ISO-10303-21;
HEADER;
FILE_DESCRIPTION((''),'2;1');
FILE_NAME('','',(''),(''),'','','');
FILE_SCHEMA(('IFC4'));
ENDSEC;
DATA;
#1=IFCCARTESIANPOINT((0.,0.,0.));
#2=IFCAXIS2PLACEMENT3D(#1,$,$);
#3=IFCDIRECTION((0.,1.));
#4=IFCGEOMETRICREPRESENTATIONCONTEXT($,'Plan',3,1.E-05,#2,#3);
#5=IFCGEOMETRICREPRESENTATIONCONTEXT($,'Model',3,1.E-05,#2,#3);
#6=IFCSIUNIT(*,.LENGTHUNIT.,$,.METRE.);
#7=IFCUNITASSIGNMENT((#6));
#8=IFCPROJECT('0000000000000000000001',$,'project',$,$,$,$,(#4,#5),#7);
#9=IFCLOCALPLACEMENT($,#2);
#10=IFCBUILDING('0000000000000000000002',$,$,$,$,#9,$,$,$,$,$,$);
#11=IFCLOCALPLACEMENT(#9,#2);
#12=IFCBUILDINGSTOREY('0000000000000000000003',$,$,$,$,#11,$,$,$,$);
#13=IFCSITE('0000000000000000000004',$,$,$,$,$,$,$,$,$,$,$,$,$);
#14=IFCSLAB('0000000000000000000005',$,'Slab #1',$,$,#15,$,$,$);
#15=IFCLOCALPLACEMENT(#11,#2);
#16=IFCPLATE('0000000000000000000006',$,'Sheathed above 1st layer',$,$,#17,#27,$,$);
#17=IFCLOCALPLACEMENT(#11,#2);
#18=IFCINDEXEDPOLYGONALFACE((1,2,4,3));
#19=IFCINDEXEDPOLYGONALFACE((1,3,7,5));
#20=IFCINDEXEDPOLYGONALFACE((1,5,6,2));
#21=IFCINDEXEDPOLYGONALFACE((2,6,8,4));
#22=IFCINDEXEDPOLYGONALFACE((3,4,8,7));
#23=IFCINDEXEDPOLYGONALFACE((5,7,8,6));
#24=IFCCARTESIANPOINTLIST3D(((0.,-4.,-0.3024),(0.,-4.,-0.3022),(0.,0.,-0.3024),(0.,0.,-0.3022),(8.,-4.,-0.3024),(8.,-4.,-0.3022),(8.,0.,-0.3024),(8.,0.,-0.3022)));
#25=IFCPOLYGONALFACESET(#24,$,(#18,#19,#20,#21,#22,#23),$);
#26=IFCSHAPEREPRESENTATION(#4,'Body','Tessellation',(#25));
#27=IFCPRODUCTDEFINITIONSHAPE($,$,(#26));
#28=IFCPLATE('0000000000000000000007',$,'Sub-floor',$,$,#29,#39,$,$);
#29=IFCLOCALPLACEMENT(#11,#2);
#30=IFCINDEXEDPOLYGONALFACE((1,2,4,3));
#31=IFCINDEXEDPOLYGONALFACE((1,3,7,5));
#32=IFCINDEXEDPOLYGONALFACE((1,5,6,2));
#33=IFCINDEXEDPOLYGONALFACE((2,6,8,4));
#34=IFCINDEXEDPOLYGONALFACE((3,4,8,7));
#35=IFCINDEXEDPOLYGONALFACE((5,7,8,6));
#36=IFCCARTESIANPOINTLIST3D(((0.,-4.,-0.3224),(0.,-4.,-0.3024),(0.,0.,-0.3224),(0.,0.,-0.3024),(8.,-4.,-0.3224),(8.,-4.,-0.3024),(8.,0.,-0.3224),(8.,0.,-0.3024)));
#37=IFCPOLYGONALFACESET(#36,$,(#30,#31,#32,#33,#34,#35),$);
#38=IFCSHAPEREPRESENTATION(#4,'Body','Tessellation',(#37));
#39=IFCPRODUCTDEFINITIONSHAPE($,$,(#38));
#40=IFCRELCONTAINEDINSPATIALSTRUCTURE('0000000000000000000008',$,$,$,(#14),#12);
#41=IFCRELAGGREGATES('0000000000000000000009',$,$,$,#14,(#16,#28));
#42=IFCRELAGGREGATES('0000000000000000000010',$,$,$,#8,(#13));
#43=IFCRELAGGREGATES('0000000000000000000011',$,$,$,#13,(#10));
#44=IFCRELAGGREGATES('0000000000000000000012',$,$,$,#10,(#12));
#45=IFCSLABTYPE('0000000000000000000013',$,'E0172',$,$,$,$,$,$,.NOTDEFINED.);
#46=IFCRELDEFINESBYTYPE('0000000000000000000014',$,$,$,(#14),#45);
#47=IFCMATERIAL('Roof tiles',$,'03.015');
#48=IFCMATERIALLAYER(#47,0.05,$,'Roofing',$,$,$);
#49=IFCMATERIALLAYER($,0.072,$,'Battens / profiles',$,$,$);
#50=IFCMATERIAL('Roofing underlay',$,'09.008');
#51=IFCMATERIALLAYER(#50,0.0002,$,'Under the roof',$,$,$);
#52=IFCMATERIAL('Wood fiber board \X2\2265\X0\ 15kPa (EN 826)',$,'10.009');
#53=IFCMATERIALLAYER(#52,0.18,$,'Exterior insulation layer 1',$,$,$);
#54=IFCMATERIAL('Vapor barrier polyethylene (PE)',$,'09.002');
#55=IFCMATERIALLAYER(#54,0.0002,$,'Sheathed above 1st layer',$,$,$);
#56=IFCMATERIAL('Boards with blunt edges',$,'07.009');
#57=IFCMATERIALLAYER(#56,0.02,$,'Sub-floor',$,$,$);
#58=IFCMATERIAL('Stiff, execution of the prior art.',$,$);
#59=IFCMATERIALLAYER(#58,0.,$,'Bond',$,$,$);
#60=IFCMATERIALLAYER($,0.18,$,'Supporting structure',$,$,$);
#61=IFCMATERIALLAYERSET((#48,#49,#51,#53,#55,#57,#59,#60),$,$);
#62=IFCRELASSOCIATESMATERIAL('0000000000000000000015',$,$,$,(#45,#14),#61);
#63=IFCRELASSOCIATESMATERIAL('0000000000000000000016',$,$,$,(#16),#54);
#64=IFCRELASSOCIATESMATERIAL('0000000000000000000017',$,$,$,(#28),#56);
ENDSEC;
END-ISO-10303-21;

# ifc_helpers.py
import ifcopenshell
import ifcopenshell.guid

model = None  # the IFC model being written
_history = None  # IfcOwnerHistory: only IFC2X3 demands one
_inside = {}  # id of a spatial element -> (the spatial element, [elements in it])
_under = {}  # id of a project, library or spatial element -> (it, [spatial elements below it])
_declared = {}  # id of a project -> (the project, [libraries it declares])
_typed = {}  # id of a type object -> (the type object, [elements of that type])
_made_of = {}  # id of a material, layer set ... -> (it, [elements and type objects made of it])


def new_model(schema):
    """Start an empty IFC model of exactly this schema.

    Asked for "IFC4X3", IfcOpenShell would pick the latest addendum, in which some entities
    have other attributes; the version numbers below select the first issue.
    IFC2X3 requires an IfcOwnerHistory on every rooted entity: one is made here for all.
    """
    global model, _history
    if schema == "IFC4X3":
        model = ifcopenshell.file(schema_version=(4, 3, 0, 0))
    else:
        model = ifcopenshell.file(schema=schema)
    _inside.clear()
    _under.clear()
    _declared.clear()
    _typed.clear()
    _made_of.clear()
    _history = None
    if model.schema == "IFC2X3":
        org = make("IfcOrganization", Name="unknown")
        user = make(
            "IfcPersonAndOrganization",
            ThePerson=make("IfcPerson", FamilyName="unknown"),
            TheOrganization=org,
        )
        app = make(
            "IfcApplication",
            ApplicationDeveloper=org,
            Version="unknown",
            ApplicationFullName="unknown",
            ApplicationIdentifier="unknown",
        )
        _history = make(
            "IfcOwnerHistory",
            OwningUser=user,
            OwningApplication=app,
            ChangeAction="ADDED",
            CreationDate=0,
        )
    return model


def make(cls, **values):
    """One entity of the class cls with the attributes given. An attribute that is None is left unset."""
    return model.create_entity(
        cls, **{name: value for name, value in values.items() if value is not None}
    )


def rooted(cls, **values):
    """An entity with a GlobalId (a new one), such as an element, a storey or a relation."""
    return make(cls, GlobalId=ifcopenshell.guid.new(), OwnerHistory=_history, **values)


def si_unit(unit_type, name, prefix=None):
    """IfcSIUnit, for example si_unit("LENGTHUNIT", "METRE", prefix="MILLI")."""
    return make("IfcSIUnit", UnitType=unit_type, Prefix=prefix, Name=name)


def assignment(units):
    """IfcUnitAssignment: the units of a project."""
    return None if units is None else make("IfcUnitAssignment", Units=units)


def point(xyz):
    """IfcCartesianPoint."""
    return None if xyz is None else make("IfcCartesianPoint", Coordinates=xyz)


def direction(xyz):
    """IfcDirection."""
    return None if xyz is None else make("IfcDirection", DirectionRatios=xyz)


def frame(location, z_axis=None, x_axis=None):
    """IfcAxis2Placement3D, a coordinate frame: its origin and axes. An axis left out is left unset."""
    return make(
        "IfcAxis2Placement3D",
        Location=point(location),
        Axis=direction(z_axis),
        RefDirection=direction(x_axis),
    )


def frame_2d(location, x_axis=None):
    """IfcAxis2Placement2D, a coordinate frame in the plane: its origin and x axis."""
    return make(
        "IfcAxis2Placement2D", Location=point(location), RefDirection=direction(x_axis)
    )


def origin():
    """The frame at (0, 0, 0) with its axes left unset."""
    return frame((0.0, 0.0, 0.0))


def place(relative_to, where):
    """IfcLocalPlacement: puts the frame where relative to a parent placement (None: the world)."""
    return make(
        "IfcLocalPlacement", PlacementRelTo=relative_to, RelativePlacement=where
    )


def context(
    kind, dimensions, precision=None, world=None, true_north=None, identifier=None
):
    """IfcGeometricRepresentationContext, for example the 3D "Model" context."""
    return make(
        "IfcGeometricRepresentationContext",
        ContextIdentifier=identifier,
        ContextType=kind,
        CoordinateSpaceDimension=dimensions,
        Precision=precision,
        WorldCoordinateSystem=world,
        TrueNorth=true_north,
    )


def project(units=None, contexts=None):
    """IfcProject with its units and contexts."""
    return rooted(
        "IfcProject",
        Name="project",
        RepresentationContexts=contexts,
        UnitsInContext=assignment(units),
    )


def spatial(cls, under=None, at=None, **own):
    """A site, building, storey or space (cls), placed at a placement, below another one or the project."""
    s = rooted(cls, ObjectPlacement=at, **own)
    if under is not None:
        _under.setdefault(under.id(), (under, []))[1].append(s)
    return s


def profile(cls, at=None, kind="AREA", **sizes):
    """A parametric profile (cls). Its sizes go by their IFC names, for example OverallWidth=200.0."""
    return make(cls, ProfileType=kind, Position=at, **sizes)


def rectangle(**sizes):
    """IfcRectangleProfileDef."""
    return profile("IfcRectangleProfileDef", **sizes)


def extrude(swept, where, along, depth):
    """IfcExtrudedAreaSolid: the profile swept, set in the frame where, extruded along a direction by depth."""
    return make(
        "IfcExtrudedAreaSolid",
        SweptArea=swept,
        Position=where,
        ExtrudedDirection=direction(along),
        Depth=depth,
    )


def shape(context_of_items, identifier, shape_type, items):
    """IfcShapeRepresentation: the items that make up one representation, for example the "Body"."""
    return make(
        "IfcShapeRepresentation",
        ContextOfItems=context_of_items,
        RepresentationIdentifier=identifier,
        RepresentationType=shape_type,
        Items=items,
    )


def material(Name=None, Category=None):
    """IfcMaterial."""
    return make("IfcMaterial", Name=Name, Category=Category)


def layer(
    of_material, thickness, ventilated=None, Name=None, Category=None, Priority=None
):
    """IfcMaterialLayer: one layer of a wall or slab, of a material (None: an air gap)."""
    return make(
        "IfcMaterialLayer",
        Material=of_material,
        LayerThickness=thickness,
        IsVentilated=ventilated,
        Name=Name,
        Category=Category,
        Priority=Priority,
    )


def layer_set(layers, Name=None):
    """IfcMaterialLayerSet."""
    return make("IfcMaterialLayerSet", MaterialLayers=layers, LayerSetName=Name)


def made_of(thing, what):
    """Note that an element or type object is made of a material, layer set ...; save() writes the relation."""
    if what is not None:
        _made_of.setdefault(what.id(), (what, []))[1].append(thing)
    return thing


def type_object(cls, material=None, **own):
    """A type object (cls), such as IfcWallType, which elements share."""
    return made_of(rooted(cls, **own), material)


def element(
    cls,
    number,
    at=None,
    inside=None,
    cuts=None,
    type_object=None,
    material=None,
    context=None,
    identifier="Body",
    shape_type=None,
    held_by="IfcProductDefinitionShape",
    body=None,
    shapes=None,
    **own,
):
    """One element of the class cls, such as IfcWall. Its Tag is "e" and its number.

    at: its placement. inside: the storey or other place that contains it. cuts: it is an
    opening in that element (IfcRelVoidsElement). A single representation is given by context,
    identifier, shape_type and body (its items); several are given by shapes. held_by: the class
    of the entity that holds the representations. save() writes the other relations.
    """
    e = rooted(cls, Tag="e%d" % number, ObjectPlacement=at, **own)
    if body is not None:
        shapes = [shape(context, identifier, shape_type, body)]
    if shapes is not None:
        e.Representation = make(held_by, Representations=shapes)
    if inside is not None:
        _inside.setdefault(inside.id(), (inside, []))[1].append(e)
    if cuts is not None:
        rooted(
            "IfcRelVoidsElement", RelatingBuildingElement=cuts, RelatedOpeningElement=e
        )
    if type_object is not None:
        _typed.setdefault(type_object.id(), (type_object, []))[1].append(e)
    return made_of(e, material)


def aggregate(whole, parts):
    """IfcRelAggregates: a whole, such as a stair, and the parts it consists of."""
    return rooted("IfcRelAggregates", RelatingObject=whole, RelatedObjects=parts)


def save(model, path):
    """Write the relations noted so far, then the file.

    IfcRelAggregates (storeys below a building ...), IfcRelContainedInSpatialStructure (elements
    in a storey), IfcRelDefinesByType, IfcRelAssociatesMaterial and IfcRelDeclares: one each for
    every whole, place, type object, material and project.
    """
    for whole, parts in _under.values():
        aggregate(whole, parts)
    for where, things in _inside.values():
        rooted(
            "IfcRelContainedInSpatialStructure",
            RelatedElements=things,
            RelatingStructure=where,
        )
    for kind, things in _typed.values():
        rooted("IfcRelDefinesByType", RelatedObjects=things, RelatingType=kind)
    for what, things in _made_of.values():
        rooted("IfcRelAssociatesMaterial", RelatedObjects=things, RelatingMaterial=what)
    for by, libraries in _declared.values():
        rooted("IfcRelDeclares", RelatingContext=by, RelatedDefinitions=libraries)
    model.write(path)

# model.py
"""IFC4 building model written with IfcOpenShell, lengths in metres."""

from ifc_helpers import new_model, si_unit, direction, frame, frame_2d, origin, place, context, project, spatial, rectangle, extrude, material, layer, layer_set, type_object, element, aggregate, save


model = new_model("IFC4")

# Units and contexts
plan_context = context("Plan", 3, precision=1e-05, world=origin(), true_north=direction((0.0, 1.0)))
model_context = context("Model", 3, precision=1e-05, world=origin(), true_north=direction((0.0, 1.0)))
ifc_project = project(units=[si_unit("LENGTHUNIT", "METRE")], contexts=[plan_context, model_context])

# Site, building, storey
site = spatial("IfcSite", under=ifc_project)
building_placement = place(None, origin())
building = spatial("IfcBuilding", under=site, at=building_placement)
storey_placement = place(building_placement, origin())
storey = spatial("IfcBuildingStorey", under=building, at=storey_placement)

# Slab, plates
ifc_material_1 = material(Name="Roof tiles", Category="03.015")
ifc_layer_1 = layer(ifc_material_1, 0.05, Name="Roofing")
ifc_layer_2 = layer(None, 0.072, Name="Battens / profiles")
ifc_material_2 = material(Name="Roofing underlay", Category="09.008")
ifc_layer_3 = layer(ifc_material_2, 0.0002, Name="Under the roof")
ifc_material_3 = material(Name="Wood fiber board ≥ 15kPa (EN 826)", Category="10.009")
ifc_layer_4 = layer(ifc_material_3, 0.18, Name="Exterior insulation layer 1")
ifc_material_4 = material(Name="Vapor barrier polyethylene (PE)", Category="09.002")
ifc_layer_5 = layer(ifc_material_4, 0.0002, Name="Sheathed above 1st layer")
ifc_material_5 = material(Name="Boards with blunt edges", Category="07.009")
ifc_layer_6 = layer(ifc_material_5, 0.02, Name="Sub-floor")
ifc_material_6 = material(Name="Stiff, execution of the prior art.")
ifc_layer_7 = layer(ifc_material_6, 0.0, Name="Bond")
ifc_layer_8 = layer(None, 0.18, Name="Supporting structure")
ifc_layer_set = layer_set([ifc_layer_1, ifc_layer_2, ifc_layer_3, ifc_layer_4, ifc_layer_5, ifc_layer_6, ifc_layer_7, ifc_layer_8])
slab_type = type_object("IfcSlabType", Name="E0172", PredefinedType="NOTDEFINED", material=ifc_layer_set)
slab_placement = place(None, frame((0.0, 0.0, 0.0), z_axis=(0.0, 0.0, -1.0), x_axis=(1.0, 0.0, 0.0)))
slab = element("IfcSlab", 1, at=slab_placement, inside=storey, type_object=slab_type, material=ifc_layer_set, Name="Slab #1")
plate_1_placement = place(slab_placement, origin())
plate_1 = element("IfcPlate", 2, at=plate_1_placement, material=ifc_material_4, Name="Sheathed above 1st layer", context=plan_context, shape_type="SweptSolid", body=[
    extrude(rectangle(XDim=8.0, YDim=4.0, at=frame_2d((4.0, 2.0), x_axis=(1.0, 0.0))), frame((0.0, 0.0, 0.3022), z_axis=(0.0, 0.0, 1.0), x_axis=(1.0, 0.0, 0.0)), (0.0, 0.0, 1.0), 0.0002),
])
plate_2_placement = place(slab_placement, origin())
plate_2 = element("IfcPlate", 3, at=plate_2_placement, material=ifc_material_5, Name="Sub-floor", context=plan_context, shape_type="SweptSolid", body=[
    extrude(rectangle(XDim=8.0, YDim=4.0, at=frame_2d((4.0, 2.0), x_axis=(1.0, 0.0))), frame((0.0, 0.0, 0.3024), z_axis=(0.0, 0.0, 1.0), x_axis=(1.0, 0.0, 0.0)), (0.0, 0.0, 1.0), 0.02),
])
aggregate(slab, [plate_1, plate_2])

save(model, "model.ifc")
